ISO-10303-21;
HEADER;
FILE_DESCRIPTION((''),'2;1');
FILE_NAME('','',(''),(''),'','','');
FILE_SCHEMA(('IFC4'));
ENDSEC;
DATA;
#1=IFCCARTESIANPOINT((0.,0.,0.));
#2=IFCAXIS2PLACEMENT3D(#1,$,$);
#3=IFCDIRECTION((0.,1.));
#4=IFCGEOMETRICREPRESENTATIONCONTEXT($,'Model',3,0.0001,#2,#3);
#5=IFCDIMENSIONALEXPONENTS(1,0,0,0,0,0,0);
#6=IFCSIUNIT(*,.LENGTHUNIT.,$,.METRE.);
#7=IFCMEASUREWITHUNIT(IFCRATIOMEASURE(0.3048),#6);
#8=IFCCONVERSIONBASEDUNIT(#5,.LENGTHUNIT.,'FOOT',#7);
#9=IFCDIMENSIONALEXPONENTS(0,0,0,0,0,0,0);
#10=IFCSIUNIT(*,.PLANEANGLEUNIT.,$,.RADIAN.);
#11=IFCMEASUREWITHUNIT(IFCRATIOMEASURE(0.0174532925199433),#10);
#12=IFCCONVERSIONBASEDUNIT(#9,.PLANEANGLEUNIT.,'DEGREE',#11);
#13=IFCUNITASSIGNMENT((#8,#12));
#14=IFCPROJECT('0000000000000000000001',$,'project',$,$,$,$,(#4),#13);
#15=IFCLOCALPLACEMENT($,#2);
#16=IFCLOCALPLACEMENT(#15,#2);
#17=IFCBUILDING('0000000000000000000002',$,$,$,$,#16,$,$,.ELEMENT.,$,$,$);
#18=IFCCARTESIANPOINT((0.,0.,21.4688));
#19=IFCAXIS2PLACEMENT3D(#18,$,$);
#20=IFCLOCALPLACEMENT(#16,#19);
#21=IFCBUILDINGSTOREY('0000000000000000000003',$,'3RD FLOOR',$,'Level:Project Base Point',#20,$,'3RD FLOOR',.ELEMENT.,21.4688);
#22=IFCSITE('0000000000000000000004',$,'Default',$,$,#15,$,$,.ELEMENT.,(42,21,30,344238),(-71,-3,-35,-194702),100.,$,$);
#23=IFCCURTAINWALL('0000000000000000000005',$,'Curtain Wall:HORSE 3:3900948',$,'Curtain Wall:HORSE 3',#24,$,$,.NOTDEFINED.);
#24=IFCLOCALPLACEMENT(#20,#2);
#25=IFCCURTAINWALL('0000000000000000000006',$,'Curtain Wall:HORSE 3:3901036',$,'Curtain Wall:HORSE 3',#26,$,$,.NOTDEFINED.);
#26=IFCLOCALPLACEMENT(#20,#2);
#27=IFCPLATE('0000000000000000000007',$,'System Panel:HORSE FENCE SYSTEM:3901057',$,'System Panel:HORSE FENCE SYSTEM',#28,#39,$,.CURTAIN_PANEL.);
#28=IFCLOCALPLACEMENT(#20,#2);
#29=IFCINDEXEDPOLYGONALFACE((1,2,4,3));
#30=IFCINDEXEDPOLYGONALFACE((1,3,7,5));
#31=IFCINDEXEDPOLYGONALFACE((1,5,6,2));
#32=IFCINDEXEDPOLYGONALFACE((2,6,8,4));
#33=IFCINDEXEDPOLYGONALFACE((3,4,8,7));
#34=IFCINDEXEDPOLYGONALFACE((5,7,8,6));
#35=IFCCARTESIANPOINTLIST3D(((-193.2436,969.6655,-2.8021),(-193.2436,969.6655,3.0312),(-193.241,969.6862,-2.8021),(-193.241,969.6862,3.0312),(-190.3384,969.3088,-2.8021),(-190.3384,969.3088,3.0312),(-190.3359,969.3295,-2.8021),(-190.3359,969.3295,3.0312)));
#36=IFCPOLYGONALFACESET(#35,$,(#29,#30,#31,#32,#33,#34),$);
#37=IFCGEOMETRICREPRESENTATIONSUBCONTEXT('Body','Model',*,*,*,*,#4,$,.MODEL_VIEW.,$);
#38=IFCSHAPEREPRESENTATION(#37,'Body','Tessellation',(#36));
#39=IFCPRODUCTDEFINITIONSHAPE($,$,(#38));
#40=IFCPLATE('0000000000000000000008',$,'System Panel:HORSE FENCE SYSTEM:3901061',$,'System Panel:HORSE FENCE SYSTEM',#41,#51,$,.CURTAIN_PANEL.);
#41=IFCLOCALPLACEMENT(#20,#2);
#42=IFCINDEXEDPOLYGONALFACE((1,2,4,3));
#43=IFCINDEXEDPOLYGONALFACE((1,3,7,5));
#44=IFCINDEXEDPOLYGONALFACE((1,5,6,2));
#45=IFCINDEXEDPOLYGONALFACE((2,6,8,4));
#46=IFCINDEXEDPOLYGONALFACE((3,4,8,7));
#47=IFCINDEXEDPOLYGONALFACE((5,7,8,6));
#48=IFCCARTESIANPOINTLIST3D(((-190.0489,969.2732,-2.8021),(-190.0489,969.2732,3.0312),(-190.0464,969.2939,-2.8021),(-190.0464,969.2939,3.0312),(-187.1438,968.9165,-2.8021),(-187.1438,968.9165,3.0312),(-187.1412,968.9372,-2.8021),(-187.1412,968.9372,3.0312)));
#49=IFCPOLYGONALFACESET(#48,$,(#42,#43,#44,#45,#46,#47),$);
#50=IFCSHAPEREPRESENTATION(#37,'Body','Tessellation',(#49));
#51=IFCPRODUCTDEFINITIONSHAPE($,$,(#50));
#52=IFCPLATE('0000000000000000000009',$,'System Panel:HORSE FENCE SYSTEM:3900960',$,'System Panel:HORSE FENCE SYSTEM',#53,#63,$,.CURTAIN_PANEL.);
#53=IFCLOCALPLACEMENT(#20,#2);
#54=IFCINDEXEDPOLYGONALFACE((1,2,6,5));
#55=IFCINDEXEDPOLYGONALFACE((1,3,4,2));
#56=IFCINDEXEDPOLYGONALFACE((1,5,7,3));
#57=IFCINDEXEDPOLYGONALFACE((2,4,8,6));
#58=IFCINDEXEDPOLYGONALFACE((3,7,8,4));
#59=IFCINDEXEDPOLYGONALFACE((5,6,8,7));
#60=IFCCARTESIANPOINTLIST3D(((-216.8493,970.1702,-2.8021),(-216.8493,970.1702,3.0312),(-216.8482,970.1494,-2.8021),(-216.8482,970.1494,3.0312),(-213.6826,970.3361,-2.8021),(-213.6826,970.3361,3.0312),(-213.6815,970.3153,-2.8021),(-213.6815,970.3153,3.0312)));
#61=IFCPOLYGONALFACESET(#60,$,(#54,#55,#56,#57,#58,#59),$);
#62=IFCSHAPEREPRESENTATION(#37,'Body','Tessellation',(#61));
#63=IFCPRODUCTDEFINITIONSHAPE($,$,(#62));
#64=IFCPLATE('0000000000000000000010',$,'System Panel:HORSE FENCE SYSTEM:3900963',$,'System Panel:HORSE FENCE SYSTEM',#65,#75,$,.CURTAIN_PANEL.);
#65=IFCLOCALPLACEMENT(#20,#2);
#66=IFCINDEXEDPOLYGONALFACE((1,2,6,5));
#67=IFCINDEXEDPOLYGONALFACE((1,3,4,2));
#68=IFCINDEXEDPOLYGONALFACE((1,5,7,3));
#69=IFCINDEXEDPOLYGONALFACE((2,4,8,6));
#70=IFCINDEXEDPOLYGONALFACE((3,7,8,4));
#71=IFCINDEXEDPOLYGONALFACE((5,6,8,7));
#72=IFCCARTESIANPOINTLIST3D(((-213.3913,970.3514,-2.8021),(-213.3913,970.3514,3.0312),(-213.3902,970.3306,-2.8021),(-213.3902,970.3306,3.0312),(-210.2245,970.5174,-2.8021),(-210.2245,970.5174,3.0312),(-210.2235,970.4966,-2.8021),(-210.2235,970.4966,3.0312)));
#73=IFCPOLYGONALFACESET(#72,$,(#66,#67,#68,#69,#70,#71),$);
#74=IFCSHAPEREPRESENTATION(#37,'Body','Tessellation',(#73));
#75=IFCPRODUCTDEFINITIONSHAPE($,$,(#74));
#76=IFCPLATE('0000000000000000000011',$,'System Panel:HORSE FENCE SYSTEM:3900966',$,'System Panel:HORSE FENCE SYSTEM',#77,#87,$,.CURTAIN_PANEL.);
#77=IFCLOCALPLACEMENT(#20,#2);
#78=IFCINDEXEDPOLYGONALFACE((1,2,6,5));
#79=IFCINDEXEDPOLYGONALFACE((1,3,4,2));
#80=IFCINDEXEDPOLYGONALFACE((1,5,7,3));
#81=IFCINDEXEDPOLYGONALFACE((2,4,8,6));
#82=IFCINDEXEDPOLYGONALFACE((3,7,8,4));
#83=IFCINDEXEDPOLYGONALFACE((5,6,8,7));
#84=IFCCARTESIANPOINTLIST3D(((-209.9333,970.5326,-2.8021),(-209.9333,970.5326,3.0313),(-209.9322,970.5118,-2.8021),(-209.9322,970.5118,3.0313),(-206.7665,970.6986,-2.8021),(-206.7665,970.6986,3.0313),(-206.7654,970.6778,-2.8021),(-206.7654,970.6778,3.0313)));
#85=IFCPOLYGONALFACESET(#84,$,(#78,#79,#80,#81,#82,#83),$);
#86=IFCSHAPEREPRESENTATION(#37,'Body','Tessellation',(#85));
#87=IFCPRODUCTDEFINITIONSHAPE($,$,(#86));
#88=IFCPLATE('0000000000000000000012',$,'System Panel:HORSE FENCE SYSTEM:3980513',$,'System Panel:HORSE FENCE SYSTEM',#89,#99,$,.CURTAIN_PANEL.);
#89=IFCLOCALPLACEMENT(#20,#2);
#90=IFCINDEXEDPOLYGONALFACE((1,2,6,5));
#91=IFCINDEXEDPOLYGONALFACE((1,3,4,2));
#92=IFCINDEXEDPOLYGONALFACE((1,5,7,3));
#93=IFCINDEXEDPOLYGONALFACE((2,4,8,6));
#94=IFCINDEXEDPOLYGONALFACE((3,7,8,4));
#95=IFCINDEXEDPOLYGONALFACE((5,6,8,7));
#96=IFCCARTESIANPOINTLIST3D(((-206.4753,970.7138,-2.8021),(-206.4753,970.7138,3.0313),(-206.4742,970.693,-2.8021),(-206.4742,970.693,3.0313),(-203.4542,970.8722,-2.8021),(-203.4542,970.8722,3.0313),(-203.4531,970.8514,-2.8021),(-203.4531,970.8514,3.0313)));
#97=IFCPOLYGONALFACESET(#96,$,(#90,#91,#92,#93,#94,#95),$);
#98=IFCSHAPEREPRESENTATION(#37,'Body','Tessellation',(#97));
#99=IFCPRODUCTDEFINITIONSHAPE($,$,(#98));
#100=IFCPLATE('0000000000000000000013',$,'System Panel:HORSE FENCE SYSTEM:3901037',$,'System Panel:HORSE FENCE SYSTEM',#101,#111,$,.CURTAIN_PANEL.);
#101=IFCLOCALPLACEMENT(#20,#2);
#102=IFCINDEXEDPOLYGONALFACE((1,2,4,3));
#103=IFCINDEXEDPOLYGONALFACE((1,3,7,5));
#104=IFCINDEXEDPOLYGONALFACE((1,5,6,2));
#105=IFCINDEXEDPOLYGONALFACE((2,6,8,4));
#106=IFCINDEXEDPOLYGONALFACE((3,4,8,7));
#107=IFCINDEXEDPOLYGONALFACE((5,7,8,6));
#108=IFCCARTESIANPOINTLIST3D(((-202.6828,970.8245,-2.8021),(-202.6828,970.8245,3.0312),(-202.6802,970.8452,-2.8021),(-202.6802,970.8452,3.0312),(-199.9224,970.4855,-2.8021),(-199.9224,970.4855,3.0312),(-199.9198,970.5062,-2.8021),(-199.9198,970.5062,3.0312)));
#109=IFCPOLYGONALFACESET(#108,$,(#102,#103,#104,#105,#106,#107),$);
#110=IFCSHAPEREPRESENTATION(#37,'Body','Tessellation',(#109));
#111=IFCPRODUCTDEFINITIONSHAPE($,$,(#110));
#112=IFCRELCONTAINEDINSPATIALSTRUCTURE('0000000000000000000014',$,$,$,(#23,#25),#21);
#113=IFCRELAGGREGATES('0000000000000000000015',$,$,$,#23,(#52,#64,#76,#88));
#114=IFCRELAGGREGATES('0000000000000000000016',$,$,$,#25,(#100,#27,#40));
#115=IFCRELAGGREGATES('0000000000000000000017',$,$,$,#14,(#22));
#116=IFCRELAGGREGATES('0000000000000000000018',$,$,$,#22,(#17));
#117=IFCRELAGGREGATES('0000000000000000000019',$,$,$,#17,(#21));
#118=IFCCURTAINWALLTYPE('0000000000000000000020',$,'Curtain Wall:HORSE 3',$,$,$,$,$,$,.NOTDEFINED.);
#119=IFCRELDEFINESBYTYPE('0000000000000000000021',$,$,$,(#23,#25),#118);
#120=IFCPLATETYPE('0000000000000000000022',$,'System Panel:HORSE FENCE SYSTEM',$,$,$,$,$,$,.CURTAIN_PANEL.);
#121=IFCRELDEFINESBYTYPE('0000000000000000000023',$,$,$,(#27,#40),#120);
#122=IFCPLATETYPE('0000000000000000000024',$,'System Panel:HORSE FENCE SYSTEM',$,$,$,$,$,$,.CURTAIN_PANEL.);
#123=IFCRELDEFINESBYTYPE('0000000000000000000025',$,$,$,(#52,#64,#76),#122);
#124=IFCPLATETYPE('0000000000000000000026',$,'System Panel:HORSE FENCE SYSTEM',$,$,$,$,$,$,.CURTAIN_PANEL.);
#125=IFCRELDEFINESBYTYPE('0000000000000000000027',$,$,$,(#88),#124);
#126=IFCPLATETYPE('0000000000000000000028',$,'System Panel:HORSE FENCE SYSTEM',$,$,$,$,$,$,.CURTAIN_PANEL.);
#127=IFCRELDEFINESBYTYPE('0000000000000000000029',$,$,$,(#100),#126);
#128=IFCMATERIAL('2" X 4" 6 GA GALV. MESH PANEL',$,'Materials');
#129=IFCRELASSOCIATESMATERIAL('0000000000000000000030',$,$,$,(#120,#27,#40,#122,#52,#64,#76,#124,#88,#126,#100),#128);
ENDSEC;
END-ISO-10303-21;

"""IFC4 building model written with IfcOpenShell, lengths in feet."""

from ifc_helpers import new_model, entity, si_unit, converted_unit, direction, frame, frame_2d, origin, place, context, subcontext, project, spatial, rectangle, extrude, source, transform, mapped, material, type_object, type_shapes, element, aggregate, save


model = new_model("IFC4")

# Units and contexts
model_context = context("Model", 3, precision=0.0001, world=origin(), true_north=direction((0.0, 1.0)))
body_context = subcontext(model_context, "Body", "Model", "MODEL_VIEW")
ifc_project = project(units=[converted_unit("LENGTHUNIT", "FOOT", entity("IfcRatioMeasure", 0.3048), si_unit("LENGTHUNIT", "METRE"), dimensions=[1, 0, 0, 0, 0, 0, 0]), converted_unit("PLANEANGLEUNIT", "DEGREE", entity("IfcRatioMeasure", 0.0174532925199433), si_unit("PLANEANGLEUNIT", "RADIAN"), dimensions=[0, 0, 0, 0, 0, 0, 0])], contexts=[model_context])

# Site, building, storey
site_placement = place(None, origin())
site = spatial("IfcSite", under=ifc_project, at=site_placement, Name="Default", CompositionType="ELEMENT", RefLatitude=(42, 21, 30, 344238), RefLongitude=(-71, -3, -35, -194702), RefElevation=100.0)
building_placement = place(site_placement, origin())
building = spatial("IfcBuilding", under=site, at=building_placement, CompositionType="ELEMENT")
storey_placement = place(building_placement, frame((0.0, 0.0, 21.4688)))
storey = spatial("IfcBuildingStorey", under=building, at=storey_placement, Name="3RD FLOOR", ObjectType="Level:Project Base Point", LongName="3RD FLOOR", CompositionType="ELEMENT", Elevation=21.4688)

# Curtain walls
curtain_wall_type_1 = type_object("IfcCurtainWallType", Name="Curtain Wall:HORSE 3", PredefinedType="NOTDEFINED")
curtain_wall_1_placement = place(storey_placement, frame((0.0, 0.0, -21.4688)))
curtain_wall_1 = element("IfcCurtainWall", 1, at=curtain_wall_1_placement, inside=storey, type_object=curtain_wall_type_1, Name="Curtain Wall:HORSE 3:3900948", ObjectType="Curtain Wall:HORSE 3", PredefinedType="NOTDEFINED")
curtain_wall_2_placement = place(storey_placement, frame((0.0, 0.0, -21.4688)))
curtain_wall_2 = element("IfcCurtainWall", 2, at=curtain_wall_2_placement, inside=storey, type_object=curtain_wall_type_1, Name="Curtain Wall:HORSE 3:3901036", ObjectType="Curtain Wall:HORSE 3", PredefinedType="NOTDEFINED")

# Plates
ifc_material_1 = material(Name="2\" X 4\" 6 GA GALV. MESH PANEL", Category="Materials")
plate_type_1 = type_object("IfcPlateType", Name="System Panel:HORSE FENCE SYSTEM", PredefinedType="CURTAIN_PANEL", material=ifc_material_1)
shared_shape_1 = source(origin(), body_context, "Body", "SweptSolid", [
    extrude(rectangle(XDim=0.0208, YDim=2.927, at=frame_2d((0.0, 0.0), x_axis=(1.0, 0.0))), frame((1.4635, 0.0104, 0.0), z_axis=(0.0, 0.0, 1.0), x_axis=(0.0, 1.0, 0.0)), (0.0, 0.0, 1.0), 5.8333),
])
type_shapes(plate_type_1, [shared_shape_1])
plate_1_placement = place(curtain_wall_2_placement, frame((-193.2436, 969.6655, 18.6667), z_axis=(0.0, 0.0, 1.0), x_axis=(0.992546, -0.121869, 0.0)))
plate_1 = element("IfcPlate", 3, at=plate_1_placement, type_object=plate_type_1, material=ifc_material_1, Name="System Panel:HORSE FENCE SYSTEM:3901057", ObjectType="System Panel:HORSE FENCE SYSTEM", PredefinedType="CURTAIN_PANEL", context=body_context, shape_type="MappedRepresentation", body=[
    mapped(shared_shape_1, transform((0.0, 0.0, 0.0), scale=1.0)),
])
plate_2_placement = place(curtain_wall_2_placement, frame((-190.0489, 969.2732, 18.6667), z_axis=(0.0, 0.0, 1.0), x_axis=(0.992546, -0.121869, 0.0)))
plate_2 = element("IfcPlate", 4, at=plate_2_placement, type_object=plate_type_1, material=ifc_material_1, Name="System Panel:HORSE FENCE SYSTEM:3901061", ObjectType="System Panel:HORSE FENCE SYSTEM", PredefinedType="CURTAIN_PANEL", context=body_context, shape_type="MappedRepresentation", body=[
    mapped(shared_shape_1, transform((0.0, 0.0, 0.0), scale=1.0)),
])
plate_type_2 = type_object("IfcPlateType", Name="System Panel:HORSE FENCE SYSTEM", PredefinedType="CURTAIN_PANEL", material=ifc_material_1)
shared_shape_2 = source(origin(), body_context, "Body", "SweptSolid", [
    extrude(rectangle(XDim=0.0208, YDim=3.1711, at=frame_2d((0.0, 0.0), x_axis=(1.0, 0.0))), frame((1.5855, 0.0104, 0.0), z_axis=(0.0, 0.0, 1.0), x_axis=(0.0, 1.0, 0.0)), (0.0, 0.0, 1.0), 5.8333),
])
type_shapes(plate_type_2, [shared_shape_2])
plate_3_placement = place(curtain_wall_1_placement, frame((-216.8482, 970.1494, 18.6667), z_axis=(0.0, 0.0, 1.0), x_axis=(0.99863, 0.052336, 0.0)))
plate_3 = element("IfcPlate", 5, at=plate_3_placement, type_object=plate_type_2, material=ifc_material_1, Name="System Panel:HORSE FENCE SYSTEM:3900960", ObjectType="System Panel:HORSE FENCE SYSTEM", PredefinedType="CURTAIN_PANEL", context=body_context, shape_type="MappedRepresentation", body=[
    mapped(shared_shape_2, transform((0.0, 0.0, 0.0), scale=1.0)),
])
plate_4_placement = place(curtain_wall_1_placement, frame((-213.3902, 970.3306, 18.6667), z_axis=(0.0, 0.0, 1.0), x_axis=(0.99863, 0.052336, 0.0)))
plate_4 = element("IfcPlate", 6, at=plate_4_placement, type_object=plate_type_2, material=ifc_material_1, Name="System Panel:HORSE FENCE SYSTEM:3900963", ObjectType="System Panel:HORSE FENCE SYSTEM", PredefinedType="CURTAIN_PANEL", context=body_context, shape_type="MappedRepresentation", body=[
    mapped(shared_shape_2, transform((0.0, 0.0, 0.0), scale=1.0)),
])
plate_5_placement = place(curtain_wall_1_placement, frame((-209.9322, 970.5118, 18.6667), z_axis=(0.0, 0.0, 1.0), x_axis=(0.99863, 0.052336, 0.0)))
plate_5 = element("IfcPlate", 7, at=plate_5_placement, type_object=plate_type_2, material=ifc_material_1, Name="System Panel:HORSE FENCE SYSTEM:3900966", ObjectType="System Panel:HORSE FENCE SYSTEM", PredefinedType="CURTAIN_PANEL", context=body_context, shape_type="MappedRepresentation", body=[
    mapped(shared_shape_2, transform((0.0, 0.0, 0.0), scale=1.0)),
])
plate_type_3 = type_object("IfcPlateType", Name="System Panel:HORSE FENCE SYSTEM", PredefinedType="CURTAIN_PANEL", material=ifc_material_1)
shared_shape_3 = source(origin(), body_context, "Body", "SweptSolid", [
    extrude(rectangle(XDim=0.0208, YDim=3.0253, at=frame_2d((0.0, 0.0), x_axis=(1.0, 0.0))), frame((1.5126, 0.0104, 0.0), z_axis=(0.0, 0.0, 1.0), x_axis=(0.0, 1.0, 0.0)), (0.0, 0.0, 1.0), 5.8333),
])
type_shapes(plate_type_3, [shared_shape_3])
plate_6_placement = place(curtain_wall_1_placement, frame((-206.4742, 970.693, 18.6667), z_axis=(0.0, 0.0, 1.0), x_axis=(0.99863, 0.052336, 0.0)))
plate_6 = element("IfcPlate", 8, at=plate_6_placement, type_object=plate_type_3, material=ifc_material_1, Name="System Panel:HORSE FENCE SYSTEM:3980513", ObjectType="System Panel:HORSE FENCE SYSTEM", PredefinedType="CURTAIN_PANEL", context=body_context, shape_type="MappedRepresentation", body=[
    mapped(shared_shape_3, transform((0.0, 0.0, 0.0), scale=1.0)),
])
aggregate(curtain_wall_1, [plate_3, plate_4, plate_5, plate_6])
plate_type_4 = type_object("IfcPlateType", Name="System Panel:HORSE FENCE SYSTEM", PredefinedType="CURTAIN_PANEL", material=ifc_material_1)
shared_shape_4 = source(origin(), body_context, "Body", "SweptSolid", [
    extrude(rectangle(XDim=0.0208, YDim=2.7811, at=frame_2d((0.0, 0.0), x_axis=(1.0, 0.0))), frame((1.3906, 0.0104, 0.0), z_axis=(0.0, 0.0, 1.0), x_axis=(0.0, 1.0, 0.0)), (0.0, 0.0, 1.0), 5.8333),
])
type_shapes(plate_type_4, [shared_shape_4])
plate_7_placement = place(curtain_wall_2_placement, frame((-202.6828, 970.8245, 18.6667), z_axis=(0.0, 0.0, 1.0), x_axis=(0.992546, -0.121869, 0.0)))
plate_7 = element("IfcPlate", 9, at=plate_7_placement, type_object=plate_type_4, material=ifc_material_1, Name="System Panel:HORSE FENCE SYSTEM:3901037", ObjectType="System Panel:HORSE FENCE SYSTEM", PredefinedType="CURTAIN_PANEL", context=body_context, shape_type="MappedRepresentation", body=[
    mapped(shared_shape_4, transform((0.0, 0.0, 0.0), scale=1.0)),
])
aggregate(curtain_wall_2, [plate_7, plate_1, plate_2])

save(model, "model.ifc")
